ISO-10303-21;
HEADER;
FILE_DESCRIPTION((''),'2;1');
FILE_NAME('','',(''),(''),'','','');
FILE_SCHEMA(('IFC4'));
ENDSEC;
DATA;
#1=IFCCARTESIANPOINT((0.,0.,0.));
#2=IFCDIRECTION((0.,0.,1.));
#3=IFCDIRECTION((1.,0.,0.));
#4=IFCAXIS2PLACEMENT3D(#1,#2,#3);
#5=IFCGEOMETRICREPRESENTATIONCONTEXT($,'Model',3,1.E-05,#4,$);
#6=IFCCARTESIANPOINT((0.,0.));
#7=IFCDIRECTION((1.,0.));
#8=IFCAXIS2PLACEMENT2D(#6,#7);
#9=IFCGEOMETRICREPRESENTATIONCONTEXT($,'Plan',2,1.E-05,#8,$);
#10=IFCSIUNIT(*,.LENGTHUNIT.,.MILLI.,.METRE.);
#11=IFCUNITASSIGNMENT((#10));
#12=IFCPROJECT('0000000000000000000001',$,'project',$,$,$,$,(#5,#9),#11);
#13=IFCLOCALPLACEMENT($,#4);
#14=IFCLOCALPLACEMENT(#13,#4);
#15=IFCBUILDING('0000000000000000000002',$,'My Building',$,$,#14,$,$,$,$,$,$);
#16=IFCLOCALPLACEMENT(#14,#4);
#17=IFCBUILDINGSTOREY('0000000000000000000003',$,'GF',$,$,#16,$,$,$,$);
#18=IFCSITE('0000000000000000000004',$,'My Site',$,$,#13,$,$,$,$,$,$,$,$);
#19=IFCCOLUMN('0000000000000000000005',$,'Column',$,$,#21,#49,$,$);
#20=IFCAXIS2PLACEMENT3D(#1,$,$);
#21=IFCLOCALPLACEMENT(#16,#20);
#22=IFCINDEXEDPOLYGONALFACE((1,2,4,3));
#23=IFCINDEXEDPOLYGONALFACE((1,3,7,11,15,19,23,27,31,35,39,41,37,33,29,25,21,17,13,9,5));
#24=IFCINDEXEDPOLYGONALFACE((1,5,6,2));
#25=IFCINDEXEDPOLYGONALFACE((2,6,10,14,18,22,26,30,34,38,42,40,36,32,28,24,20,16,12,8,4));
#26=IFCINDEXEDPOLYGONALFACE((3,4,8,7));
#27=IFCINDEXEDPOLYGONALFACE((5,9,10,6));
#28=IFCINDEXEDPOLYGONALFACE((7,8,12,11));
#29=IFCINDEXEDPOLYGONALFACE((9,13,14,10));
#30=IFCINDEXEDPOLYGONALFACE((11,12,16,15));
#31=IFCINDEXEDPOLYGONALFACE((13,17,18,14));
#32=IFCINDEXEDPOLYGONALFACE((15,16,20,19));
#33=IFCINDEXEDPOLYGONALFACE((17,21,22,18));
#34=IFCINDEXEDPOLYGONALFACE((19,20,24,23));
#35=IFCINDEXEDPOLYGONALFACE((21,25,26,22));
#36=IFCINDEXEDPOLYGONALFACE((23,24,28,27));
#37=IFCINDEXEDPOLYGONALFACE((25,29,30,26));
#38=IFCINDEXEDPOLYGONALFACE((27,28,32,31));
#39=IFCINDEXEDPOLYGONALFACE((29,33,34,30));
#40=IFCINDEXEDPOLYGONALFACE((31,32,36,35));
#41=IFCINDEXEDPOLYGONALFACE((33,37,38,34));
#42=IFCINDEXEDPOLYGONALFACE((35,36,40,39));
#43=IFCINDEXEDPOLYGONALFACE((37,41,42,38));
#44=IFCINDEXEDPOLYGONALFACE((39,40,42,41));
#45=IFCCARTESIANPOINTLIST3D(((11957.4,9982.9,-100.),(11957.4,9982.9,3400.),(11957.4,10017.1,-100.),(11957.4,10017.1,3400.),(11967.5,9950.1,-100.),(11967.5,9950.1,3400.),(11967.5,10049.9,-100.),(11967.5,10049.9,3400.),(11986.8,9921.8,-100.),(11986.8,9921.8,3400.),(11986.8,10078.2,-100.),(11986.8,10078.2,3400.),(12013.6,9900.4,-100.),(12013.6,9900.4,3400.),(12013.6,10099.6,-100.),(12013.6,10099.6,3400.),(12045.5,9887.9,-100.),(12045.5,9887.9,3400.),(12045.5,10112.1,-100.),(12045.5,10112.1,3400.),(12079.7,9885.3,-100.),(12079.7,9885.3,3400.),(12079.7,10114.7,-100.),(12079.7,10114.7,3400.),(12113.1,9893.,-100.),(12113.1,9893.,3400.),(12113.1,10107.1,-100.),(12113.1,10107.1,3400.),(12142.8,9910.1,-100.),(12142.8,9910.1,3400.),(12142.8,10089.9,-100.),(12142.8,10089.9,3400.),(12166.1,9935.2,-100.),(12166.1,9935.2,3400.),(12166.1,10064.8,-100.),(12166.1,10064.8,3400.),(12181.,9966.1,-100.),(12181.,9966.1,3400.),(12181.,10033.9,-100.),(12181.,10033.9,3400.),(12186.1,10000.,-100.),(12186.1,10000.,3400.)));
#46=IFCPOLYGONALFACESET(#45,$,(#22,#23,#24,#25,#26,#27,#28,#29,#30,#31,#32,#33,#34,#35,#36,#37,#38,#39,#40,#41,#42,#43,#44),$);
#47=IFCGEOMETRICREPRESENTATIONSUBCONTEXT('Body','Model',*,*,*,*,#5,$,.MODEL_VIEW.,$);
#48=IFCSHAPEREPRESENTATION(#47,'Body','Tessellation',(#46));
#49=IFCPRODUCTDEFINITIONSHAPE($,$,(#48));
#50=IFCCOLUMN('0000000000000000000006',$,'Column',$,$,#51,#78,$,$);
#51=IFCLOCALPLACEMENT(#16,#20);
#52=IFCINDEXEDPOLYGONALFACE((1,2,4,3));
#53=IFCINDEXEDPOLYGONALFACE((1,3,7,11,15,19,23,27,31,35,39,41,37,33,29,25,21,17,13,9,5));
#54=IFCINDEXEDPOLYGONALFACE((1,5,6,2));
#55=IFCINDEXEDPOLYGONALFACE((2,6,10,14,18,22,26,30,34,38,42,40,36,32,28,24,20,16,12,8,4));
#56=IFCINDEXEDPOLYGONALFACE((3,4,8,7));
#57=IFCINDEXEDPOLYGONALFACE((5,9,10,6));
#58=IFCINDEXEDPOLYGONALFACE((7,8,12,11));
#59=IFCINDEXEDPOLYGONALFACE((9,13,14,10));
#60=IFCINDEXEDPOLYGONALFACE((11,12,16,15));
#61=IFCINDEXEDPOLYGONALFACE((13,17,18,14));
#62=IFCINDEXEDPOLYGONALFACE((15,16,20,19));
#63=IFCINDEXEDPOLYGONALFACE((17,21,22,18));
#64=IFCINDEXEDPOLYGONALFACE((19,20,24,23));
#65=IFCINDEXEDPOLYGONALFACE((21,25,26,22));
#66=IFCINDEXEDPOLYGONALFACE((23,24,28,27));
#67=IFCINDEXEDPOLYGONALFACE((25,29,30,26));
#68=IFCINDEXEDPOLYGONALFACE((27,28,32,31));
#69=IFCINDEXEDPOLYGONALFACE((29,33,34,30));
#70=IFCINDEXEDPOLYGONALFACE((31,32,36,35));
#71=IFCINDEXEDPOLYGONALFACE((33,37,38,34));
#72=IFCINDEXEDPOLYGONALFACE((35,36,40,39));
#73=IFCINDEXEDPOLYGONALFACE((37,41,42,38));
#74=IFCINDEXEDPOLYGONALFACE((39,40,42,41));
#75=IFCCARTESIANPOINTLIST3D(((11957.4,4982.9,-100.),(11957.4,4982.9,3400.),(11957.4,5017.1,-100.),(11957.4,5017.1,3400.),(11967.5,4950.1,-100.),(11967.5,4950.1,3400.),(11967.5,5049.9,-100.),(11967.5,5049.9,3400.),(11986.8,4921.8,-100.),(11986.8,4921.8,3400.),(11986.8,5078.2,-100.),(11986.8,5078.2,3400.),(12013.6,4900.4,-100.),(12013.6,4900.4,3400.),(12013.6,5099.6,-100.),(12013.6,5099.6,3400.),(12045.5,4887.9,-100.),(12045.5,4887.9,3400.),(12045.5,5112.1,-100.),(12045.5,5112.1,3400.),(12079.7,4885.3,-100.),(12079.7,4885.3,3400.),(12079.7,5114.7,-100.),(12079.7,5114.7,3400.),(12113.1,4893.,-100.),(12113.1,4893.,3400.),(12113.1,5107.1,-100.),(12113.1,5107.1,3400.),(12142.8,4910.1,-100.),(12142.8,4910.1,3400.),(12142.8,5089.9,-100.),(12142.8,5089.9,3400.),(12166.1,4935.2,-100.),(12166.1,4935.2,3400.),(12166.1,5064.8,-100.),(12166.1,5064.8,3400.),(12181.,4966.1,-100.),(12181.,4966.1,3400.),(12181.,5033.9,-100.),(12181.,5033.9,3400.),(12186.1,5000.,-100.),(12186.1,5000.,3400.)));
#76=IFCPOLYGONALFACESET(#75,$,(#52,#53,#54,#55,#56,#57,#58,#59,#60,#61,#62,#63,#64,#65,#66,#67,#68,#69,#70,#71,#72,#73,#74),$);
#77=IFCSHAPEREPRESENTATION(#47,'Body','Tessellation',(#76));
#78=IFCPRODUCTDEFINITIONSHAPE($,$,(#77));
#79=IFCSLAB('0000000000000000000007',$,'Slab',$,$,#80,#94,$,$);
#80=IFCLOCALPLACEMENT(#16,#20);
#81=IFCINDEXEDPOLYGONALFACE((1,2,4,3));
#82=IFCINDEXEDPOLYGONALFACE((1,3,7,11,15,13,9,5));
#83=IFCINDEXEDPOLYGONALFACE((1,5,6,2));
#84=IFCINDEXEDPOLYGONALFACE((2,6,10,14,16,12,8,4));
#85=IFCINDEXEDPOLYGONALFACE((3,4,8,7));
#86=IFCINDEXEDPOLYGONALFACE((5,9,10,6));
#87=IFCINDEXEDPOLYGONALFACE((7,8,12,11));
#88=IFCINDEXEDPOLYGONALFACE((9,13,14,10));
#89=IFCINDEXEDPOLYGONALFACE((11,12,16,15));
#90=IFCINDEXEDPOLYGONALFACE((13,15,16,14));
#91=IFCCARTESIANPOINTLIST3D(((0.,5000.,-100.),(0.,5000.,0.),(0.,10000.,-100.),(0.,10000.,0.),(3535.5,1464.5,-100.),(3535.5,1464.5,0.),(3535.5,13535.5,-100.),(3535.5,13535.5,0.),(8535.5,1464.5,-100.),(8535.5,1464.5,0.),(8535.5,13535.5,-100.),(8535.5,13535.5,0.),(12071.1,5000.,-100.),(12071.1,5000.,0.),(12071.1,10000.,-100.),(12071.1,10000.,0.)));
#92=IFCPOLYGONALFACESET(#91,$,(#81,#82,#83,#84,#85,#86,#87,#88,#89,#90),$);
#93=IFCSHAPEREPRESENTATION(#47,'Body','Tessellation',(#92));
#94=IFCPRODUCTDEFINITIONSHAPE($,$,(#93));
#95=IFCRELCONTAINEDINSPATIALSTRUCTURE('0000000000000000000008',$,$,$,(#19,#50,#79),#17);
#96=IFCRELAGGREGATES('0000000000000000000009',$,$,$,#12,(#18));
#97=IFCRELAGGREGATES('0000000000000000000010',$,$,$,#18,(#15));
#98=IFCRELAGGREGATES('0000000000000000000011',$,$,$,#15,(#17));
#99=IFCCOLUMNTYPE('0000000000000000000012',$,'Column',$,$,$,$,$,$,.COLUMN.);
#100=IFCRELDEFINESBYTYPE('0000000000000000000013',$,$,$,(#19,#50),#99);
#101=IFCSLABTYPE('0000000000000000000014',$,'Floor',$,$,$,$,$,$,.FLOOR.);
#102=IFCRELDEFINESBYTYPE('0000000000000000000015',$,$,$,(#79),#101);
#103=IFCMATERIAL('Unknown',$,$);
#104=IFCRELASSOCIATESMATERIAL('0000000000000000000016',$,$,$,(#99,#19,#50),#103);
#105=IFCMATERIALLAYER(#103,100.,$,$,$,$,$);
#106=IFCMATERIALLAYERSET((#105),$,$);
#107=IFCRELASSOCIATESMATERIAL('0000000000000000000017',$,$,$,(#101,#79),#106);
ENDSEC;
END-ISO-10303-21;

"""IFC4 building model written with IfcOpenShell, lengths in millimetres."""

from ifc_helpers import new_model, si_unit, frame, origin_with_axes, origin_2d_with_axis, place, context, subcontext, project, spatial, indexed_curve, circle, outline, extrude, material, layer, layer_set, layer_usage, material_profile, profile_set, profile_usage, type_object, element, save


model = new_model("IFC4")

# Units and contexts
model_context = context("Model", 3, precision=1e-05, world=origin_with_axes())
plan_context = context("Plan", 2, precision=1e-05, world=origin_2d_with_axis())
body_context_1 = subcontext(model_context, "Body", "Model", "MODEL_VIEW")
ifc_project = project(units=[si_unit("LENGTHUNIT", "METRE", prefix="MILLI")], contexts=[model_context, plan_context])

# Site, building, storey
site_placement = place(None, origin_with_axes())
site = spatial("IfcSite", under=ifc_project, at=site_placement, Name="My Site")
building_placement = place(site_placement, origin_with_axes())
building = spatial("IfcBuilding", under=site, at=building_placement, Name="My Building")
storey_placement = place(building_placement, origin_with_axes())
storey = spatial("IfcBuildingStorey", under=building, at=storey_placement, Name="GF")

# Columns
ifc_material = material(Name="Unknown")
ifc_material_profile_1 = material_profile(ifc_material, circle(Radius=115.0))
ifc_profile_set_1 = profile_set([ifc_material_profile_1])
column_type = type_object("IfcColumnType", Name="Column", PredefinedType="COLUMN", material=ifc_profile_set_1)
ifc_profile_usage_1 = profile_usage(ifc_profile_set_1, cardinal=5)
column_1_placement = place(storey_placement, frame((12071.1, 10000.0, -100.0), z_axis=(0.0, 0.0, 1.0), x_axis=(1.0, 0.0, 0.0)))
element("IfcColumn", 1, at=column_1_placement, inside=storey, type_object=column_type, material=ifc_profile_usage_1, Name="Column", context=body_context_1, shape_type="SweptSolid", body=[
    extrude(circle(Radius=115.0), origin_with_axes(), (0.0, 0.0, 1.0), 3500.0),
])
ifc_profile_usage_2 = profile_usage(ifc_profile_set_1, cardinal=5)
column_2_placement = place(storey_placement, frame((12071.1, 5000.0, -100.0), z_axis=(0.0, 0.0, 1.0), x_axis=(1.0, 0.0, 0.0)))
element("IfcColumn", 2, at=column_2_placement, inside=storey, type_object=column_type, material=ifc_profile_usage_2, Name="Column", context=body_context_1, shape_type="SweptSolid", body=[
    extrude(circle(Radius=115.0), origin_with_axes(), (0.0, 0.0, 1.0), 3500.0),
])

# Slab
ifc_layer = layer(ifc_material, 100.0)
ifc_layer_set = layer_set([ifc_layer])
ifc_layer_usage = layer_usage(ifc_layer_set, "AXIS3", "POSITIVE", -100.0)
slab_type = type_object("IfcSlabType", Name="Floor", PredefinedType="FLOOR", material=ifc_layer_set)
slab_placement = place(storey_placement, frame((0.0, 5000.0, 0.0), z_axis=(0.0, 0.0, 1.0), x_axis=(1.0, 0.0, 0.0)))
element("IfcSlab", 3, at=slab_placement, inside=storey, type_object=slab_type, material=ifc_layer_usage, Name="Slab", context=body_context_1, shape_type="SweptSolid", body=[
    extrude(outline(indexed_curve([(0.0, 0.0), (0.0, 5000.0), (3535.5, 8535.5), (8535.5, 8535.5), (12071.1, 5000.0), (12071.1, 0.0), (8535.5, -3535.5), (3535.5, -3535.5), (0.0, 0.0)])), frame((0.0, 0.0, -100.0), z_axis=(0.0, 0.0, 1.0), x_axis=(1.0, 0.0, 0.0)), (0.0, 0.0, 1.0), 100.0),
])

save(model, "model.ifc")
